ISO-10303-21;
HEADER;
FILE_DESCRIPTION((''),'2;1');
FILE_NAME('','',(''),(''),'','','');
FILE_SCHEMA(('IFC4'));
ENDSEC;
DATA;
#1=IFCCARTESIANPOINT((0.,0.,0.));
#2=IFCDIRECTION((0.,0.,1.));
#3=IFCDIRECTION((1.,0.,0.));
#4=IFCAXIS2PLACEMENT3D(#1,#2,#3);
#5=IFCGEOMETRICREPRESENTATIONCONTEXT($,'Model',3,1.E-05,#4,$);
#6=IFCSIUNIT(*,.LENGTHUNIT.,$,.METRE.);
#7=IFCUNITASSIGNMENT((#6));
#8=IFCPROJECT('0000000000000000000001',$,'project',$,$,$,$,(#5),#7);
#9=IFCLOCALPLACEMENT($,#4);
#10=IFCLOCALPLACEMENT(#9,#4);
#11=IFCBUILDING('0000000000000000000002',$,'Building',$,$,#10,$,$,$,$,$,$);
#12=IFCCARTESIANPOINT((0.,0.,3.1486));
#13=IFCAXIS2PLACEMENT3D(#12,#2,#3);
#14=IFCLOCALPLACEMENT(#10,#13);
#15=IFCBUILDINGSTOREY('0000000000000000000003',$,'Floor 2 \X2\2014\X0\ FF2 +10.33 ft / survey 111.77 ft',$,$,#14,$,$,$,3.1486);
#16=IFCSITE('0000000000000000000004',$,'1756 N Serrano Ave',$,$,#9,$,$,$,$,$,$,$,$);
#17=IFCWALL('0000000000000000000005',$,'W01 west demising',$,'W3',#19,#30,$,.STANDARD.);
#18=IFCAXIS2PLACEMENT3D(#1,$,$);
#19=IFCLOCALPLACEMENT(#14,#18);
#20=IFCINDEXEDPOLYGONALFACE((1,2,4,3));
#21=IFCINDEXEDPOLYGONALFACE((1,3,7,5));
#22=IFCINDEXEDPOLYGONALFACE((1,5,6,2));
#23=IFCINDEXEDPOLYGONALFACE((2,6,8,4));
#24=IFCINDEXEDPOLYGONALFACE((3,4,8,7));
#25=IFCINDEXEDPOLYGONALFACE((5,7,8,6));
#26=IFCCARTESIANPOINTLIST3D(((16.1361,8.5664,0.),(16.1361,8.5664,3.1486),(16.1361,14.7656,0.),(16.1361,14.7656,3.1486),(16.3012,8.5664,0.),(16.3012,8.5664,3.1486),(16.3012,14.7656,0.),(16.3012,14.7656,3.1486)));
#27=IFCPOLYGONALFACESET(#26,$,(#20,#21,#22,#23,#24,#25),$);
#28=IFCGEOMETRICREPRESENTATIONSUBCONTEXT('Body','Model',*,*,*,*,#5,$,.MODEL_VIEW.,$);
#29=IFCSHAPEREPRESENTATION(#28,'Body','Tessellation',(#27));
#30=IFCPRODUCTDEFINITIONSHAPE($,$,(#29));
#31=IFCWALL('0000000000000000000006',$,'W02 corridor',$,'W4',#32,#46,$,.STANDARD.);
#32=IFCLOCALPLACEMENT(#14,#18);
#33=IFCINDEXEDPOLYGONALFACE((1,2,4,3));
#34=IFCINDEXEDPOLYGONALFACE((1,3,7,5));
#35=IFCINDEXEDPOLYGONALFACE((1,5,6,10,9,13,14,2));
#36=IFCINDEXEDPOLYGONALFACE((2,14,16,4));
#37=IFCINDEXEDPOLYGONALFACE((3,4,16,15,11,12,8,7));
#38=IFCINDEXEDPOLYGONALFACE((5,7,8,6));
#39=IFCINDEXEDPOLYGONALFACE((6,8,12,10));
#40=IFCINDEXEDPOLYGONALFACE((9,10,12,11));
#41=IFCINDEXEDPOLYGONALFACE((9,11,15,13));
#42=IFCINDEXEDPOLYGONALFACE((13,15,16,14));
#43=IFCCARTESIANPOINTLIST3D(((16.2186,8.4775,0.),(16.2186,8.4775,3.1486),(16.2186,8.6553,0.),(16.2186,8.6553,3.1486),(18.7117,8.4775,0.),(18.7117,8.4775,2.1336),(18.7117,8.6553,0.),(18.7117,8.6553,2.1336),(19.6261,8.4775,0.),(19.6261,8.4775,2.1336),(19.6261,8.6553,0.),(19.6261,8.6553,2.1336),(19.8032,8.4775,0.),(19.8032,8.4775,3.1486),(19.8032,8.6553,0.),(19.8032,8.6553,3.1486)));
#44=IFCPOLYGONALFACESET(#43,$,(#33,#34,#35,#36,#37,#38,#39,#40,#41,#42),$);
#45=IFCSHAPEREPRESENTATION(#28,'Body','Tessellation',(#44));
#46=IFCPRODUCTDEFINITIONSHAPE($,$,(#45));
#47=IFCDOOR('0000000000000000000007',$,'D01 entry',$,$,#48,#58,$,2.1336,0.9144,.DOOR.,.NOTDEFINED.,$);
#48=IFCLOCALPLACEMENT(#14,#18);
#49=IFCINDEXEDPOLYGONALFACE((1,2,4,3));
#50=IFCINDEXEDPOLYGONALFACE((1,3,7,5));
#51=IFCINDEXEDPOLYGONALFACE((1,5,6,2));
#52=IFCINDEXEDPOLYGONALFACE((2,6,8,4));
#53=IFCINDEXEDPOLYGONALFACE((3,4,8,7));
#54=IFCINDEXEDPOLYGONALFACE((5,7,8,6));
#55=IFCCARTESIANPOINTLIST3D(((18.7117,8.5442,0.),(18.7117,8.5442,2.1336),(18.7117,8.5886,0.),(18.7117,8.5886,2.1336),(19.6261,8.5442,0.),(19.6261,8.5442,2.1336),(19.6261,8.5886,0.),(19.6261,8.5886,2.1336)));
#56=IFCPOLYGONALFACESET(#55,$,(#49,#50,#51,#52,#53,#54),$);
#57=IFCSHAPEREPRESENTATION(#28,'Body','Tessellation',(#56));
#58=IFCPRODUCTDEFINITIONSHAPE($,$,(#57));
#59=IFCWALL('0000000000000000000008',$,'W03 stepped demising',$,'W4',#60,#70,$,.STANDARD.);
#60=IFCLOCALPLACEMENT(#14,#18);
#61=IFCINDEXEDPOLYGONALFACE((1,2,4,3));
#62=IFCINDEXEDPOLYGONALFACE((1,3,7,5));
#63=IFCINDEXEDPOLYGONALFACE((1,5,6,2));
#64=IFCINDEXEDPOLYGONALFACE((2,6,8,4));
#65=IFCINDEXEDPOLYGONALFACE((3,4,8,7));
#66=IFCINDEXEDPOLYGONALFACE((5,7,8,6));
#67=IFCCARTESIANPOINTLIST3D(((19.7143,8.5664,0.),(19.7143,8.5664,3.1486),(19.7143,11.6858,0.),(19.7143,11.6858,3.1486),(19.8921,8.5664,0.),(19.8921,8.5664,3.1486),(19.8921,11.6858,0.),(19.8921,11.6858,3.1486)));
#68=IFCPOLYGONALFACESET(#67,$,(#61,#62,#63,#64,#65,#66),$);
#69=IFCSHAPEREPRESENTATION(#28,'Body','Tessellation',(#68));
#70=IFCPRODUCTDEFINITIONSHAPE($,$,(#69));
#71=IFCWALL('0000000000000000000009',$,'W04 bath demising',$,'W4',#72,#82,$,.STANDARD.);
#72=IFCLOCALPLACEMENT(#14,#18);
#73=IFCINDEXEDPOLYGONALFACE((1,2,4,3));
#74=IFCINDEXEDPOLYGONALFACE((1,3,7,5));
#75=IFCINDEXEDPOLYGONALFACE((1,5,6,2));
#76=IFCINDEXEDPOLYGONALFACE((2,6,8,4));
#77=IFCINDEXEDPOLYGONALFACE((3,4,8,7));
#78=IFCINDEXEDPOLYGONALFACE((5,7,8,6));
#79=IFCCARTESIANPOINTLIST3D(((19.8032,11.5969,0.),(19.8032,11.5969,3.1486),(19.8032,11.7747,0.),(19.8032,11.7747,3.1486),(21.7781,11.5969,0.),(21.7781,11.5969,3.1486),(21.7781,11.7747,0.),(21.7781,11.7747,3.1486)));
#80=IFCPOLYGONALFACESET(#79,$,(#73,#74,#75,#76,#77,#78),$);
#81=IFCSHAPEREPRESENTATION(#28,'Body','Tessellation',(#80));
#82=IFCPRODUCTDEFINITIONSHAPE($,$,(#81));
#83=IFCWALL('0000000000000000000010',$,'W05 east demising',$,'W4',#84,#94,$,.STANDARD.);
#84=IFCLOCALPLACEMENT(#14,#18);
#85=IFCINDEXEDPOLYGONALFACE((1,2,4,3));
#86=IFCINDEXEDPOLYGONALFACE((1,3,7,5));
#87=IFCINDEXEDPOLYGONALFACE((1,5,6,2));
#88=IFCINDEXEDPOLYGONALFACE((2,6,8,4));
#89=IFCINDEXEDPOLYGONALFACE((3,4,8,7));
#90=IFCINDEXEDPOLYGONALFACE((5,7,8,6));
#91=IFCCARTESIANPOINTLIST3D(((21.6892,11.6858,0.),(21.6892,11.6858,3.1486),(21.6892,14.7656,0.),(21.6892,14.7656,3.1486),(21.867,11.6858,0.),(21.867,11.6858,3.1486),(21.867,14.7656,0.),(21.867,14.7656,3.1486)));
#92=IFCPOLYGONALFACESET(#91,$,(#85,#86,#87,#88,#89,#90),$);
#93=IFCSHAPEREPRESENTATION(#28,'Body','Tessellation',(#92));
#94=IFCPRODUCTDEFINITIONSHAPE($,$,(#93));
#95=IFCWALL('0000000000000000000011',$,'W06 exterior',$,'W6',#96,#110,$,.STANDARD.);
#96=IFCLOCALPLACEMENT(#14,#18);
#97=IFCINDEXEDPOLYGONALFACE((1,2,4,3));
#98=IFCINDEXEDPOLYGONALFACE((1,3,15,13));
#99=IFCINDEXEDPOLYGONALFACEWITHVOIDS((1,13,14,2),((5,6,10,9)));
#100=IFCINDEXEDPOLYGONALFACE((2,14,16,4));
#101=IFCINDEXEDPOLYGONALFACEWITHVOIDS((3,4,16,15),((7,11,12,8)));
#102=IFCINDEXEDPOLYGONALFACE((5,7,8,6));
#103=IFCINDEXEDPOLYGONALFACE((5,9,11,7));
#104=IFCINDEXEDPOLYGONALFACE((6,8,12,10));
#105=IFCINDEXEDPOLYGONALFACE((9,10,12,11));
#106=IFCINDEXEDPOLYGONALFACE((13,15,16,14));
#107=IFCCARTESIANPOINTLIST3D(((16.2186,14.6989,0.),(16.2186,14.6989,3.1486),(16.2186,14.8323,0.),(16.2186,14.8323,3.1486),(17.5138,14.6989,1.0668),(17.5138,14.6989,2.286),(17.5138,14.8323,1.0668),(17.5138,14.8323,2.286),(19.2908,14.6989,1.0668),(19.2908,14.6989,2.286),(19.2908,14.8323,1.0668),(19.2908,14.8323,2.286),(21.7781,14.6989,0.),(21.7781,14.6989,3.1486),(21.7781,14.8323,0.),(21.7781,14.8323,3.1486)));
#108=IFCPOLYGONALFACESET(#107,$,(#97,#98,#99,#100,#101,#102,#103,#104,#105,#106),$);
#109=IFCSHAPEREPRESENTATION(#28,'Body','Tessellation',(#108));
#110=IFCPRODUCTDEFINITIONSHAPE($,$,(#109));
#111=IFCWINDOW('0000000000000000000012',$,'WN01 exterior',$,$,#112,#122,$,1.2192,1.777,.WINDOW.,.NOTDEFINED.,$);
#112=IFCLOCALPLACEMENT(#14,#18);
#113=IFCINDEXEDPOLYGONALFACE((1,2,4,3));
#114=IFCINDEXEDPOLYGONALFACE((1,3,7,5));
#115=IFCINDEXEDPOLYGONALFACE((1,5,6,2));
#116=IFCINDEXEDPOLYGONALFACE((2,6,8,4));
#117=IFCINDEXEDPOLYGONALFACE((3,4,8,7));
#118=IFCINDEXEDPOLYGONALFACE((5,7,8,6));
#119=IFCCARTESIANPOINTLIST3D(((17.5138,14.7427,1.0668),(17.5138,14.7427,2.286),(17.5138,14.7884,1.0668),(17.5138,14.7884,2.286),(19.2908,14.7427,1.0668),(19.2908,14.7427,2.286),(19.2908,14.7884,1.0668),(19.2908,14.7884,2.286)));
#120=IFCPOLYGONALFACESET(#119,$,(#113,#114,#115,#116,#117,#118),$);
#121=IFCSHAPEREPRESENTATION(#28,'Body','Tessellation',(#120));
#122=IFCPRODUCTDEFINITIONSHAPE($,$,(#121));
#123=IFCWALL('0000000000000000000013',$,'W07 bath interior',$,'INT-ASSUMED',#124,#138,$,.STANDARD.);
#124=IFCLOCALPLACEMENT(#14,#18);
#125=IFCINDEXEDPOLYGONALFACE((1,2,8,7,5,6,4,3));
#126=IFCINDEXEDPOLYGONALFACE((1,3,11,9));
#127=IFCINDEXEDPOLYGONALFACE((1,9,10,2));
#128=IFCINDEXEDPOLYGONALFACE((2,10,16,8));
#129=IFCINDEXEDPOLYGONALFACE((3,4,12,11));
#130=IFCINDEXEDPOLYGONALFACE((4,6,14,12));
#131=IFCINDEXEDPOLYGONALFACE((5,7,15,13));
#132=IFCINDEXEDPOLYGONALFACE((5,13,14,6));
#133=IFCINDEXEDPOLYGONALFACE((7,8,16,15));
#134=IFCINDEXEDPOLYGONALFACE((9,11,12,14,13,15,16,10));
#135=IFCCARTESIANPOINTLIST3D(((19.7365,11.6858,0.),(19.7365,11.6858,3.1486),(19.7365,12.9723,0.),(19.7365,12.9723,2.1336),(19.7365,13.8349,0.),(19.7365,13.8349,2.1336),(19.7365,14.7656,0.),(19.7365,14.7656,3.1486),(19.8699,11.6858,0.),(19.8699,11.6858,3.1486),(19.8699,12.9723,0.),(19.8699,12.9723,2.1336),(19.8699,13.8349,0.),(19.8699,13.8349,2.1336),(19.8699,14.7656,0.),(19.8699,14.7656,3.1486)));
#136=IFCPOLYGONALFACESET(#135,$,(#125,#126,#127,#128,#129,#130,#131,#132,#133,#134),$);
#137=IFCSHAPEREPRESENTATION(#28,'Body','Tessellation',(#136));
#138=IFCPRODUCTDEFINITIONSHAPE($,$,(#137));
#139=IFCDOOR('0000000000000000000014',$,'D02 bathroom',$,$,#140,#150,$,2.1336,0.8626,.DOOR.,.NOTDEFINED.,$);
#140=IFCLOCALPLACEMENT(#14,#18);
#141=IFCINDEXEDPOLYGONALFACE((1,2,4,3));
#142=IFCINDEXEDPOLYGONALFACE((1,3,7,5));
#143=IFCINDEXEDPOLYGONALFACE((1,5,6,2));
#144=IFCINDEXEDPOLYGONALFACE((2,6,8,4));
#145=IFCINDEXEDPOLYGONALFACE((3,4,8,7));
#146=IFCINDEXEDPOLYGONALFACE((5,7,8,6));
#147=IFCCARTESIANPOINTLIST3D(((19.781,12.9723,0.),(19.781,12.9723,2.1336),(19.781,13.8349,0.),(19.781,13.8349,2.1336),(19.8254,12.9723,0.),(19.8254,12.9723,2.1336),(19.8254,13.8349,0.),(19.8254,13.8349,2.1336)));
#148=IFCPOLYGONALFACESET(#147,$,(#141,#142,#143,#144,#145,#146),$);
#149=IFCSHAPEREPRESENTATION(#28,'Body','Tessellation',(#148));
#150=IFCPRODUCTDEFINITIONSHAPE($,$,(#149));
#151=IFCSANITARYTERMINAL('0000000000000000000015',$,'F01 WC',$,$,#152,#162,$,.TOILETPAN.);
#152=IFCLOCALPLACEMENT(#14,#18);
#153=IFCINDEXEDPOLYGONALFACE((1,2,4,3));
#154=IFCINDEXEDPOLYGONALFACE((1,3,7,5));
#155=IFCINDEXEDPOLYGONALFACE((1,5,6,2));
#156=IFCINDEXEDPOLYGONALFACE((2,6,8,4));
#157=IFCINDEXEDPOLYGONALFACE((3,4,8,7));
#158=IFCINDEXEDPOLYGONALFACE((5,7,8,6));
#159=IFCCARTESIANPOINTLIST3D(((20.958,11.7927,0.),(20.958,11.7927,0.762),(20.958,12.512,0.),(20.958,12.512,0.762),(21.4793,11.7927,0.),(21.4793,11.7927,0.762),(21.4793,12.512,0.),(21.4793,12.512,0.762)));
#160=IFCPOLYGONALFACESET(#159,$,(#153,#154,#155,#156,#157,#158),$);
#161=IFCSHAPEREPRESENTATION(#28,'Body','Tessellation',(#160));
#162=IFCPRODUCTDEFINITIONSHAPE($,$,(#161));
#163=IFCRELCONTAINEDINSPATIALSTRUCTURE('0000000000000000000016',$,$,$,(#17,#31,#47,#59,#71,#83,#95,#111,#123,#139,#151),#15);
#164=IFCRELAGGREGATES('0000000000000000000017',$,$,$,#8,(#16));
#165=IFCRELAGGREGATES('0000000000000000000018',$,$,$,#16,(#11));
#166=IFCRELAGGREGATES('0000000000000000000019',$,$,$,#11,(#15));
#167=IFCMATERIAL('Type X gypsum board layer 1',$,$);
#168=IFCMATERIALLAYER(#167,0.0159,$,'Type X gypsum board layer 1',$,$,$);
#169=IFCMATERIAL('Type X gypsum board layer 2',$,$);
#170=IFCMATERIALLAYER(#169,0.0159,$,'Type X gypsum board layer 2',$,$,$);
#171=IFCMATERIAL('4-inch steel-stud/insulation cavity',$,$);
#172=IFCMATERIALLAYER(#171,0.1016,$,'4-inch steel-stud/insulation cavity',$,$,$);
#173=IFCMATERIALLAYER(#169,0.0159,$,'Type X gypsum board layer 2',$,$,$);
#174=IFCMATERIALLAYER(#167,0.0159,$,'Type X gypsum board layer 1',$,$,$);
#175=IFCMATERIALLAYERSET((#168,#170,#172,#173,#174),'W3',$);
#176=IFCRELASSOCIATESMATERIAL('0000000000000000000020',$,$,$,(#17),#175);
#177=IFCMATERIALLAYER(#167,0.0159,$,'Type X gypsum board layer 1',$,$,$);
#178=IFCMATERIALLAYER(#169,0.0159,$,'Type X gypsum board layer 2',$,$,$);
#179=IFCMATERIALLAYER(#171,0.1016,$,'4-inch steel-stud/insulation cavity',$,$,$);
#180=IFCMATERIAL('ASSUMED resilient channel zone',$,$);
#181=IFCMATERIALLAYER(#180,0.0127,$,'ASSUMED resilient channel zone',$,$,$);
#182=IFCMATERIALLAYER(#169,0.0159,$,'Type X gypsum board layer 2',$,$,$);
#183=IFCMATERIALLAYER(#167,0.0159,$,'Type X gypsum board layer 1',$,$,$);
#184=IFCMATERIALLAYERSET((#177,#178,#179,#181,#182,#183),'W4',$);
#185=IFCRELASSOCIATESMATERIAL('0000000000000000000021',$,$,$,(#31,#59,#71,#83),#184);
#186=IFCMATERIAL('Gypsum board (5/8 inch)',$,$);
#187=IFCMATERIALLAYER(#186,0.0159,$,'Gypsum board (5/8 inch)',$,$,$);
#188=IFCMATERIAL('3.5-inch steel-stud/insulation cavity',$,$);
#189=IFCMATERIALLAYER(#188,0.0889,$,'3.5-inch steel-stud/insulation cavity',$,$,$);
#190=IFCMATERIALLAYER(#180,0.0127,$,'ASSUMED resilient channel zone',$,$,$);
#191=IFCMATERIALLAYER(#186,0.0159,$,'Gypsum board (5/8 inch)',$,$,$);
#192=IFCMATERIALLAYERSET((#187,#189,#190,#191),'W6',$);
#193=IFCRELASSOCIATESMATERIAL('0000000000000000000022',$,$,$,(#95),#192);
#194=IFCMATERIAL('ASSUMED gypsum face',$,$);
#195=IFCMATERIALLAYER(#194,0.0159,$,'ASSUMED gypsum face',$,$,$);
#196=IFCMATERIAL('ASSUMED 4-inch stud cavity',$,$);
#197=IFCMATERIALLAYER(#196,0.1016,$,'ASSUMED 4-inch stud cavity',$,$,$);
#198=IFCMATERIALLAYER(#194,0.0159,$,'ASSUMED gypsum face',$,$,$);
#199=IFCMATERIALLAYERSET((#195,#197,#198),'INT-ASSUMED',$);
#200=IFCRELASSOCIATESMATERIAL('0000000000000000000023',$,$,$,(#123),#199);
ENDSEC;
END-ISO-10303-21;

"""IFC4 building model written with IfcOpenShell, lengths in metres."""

from ifc_helpers import new_model, si_unit, frame, frame_2d, origin, origin_with_axes, place, context, subcontext, project, spatial, rectangle, extrude, material, layer, layer_set, layer_usage, element, fill, save


model = new_model("IFC4")

# Units and contexts
model_context = context("Model", 3, precision=1e-05, world=origin_with_axes())
body_context = subcontext(model_context, "Body", "Model", "MODEL_VIEW")
ifc_project = project(units=[si_unit("LENGTHUNIT", "METRE")], contexts=[model_context])

# Site, building, storey
site_placement = place(None, origin_with_axes())
site = spatial("IfcSite", under=ifc_project, at=site_placement, Name="1756 N Serrano Ave")
building_placement = place(site_placement, origin_with_axes())
building = spatial("IfcBuilding", under=site, at=building_placement, Name="Building")
storey_placement = place(building_placement, frame((0.0, 0.0, 3.1486), z_axis=(0.0, 0.0, 1.0), x_axis=(1.0, 0.0, 0.0)))
storey = spatial("IfcBuildingStorey", under=building, at=storey_placement, Name="Floor 2 — FF2 +10.33 ft / survey 111.77 ft", Elevation=3.1486)

# Wall
ifc_material_1 = material(Name="Type X gypsum board layer 1")
ifc_layer_1 = layer(ifc_material_1, 0.0159, Name="Type X gypsum board layer 1")
ifc_material_2 = material(Name="Type X gypsum board layer 2")
ifc_layer_2 = layer(ifc_material_2, 0.0159, Name="Type X gypsum board layer 2")
ifc_material_3 = material(Name="4-inch steel-stud/insulation cavity")
ifc_layer_3 = layer(ifc_material_3, 0.1016, Name="4-inch steel-stud/insulation cavity")
ifc_layer_4 = layer(ifc_material_2, 0.0159, Name="Type X gypsum board layer 2")
ifc_layer_5 = layer(ifc_material_1, 0.0159, Name="Type X gypsum board layer 1")
ifc_layer_set_1 = layer_set([ifc_layer_1, ifc_layer_2, ifc_layer_3, ifc_layer_4, ifc_layer_5], Name="W3")
ifc_layer_usage_1 = layer_usage(ifc_layer_set_1, "AXIS2", "POSITIVE", -0.0825)
wall_1_placement = place(storey_placement, frame((16.2186, 8.5664, 0.0), z_axis=(0.0, 0.0, 1.0), x_axis=(0.0, 1.0, 0.0)))
element("IfcWall", 1, at=wall_1_placement, inside=storey, material=ifc_layer_usage_1, Name="W01 west demising", ObjectType="W3", PredefinedType="STANDARD", context=body_context, shape_type="SweptSolid", body=[
    extrude(rectangle(XDim=6.1992, YDim=0.1651, at=frame_2d((3.0996, 0.0))), origin(), (0.0, 0.0, 1.0), 3.1486),
])

# Wall, opening, door
ifc_layer_6 = layer(ifc_material_1, 0.0159, Name="Type X gypsum board layer 1")
ifc_layer_7 = layer(ifc_material_2, 0.0159, Name="Type X gypsum board layer 2")
ifc_layer_8 = layer(ifc_material_3, 0.1016, Name="4-inch steel-stud/insulation cavity")
ifc_material_4 = material(Name="ASSUMED resilient channel zone")
ifc_layer_9 = layer(ifc_material_4, 0.0127, Name="ASSUMED resilient channel zone")
ifc_layer_10 = layer(ifc_material_2, 0.0159, Name="Type X gypsum board layer 2")
ifc_layer_11 = layer(ifc_material_1, 0.0159, Name="Type X gypsum board layer 1")
ifc_layer_set_2 = layer_set([ifc_layer_6, ifc_layer_7, ifc_layer_8, ifc_layer_9, ifc_layer_10, ifc_layer_11], Name="W4")
ifc_layer_usage_2 = layer_usage(ifc_layer_set_2, "AXIS2", "POSITIVE", -0.0889)
wall_2_placement = place(storey_placement, frame((16.2186, 8.5664, 0.0), z_axis=(0.0, 0.0, 1.0), x_axis=(1.0, 0.0, 0.0)))
wall_2 = element("IfcWall", 2, at=wall_2_placement, inside=storey, material=ifc_layer_usage_2, Name="W02 corridor", ObjectType="W4", PredefinedType="STANDARD", context=body_context, shape_type="SweptSolid", body=[
    extrude(rectangle(XDim=3.5846, YDim=0.1778, at=frame_2d((1.7923, 0.0))), origin(), (0.0, 0.0, 1.0), 3.1486),
])
opening_1_placement = place(None, frame((19.6261, 8.5664, 3.1486), z_axis=(0.0, 0.0, 1.0), x_axis=(-1.0, 0.0, 0.0)))
opening_1 = element("IfcOpeningElement", 3, at=opening_1_placement, cuts=wall_2, PredefinedType="OPENING", context=body_context, shape_type="SweptSolid", body=[
    extrude(rectangle(XDim=0.9144, YDim=0.2083, at=frame_2d((0.4572, 0.0))), origin(), (0.0, 0.0, 1.0), 2.1336),
])
door_1_placement = place(storey_placement, frame((19.6261, 8.5664, 0.0), z_axis=(0.0, 0.0, 1.0), x_axis=(-1.0, 0.0, 0.0)))
door_1 = element("IfcDoor", 4, at=door_1_placement, inside=storey, Name="D01 entry", OperationType="NOTDEFINED", OverallHeight=2.1336, OverallWidth=0.9144, PredefinedType="DOOR", context=body_context, shape_type="SweptSolid", body=[
    extrude(rectangle(XDim=0.9144, YDim=0.0445, at=frame_2d((0.4572, 0.0))), origin(), (0.0, 0.0, 1.0), 2.1336),
])
fill(opening_1, door_1)

# Walls
ifc_layer_usage_3 = layer_usage(ifc_layer_set_2, "AXIS2", "POSITIVE", -0.0889)
wall_3_placement = place(storey_placement, frame((19.8032, 8.5664, 0.0), z_axis=(0.0, 0.0, 1.0), x_axis=(0.0, 1.0, 0.0)))
element("IfcWall", 5, at=wall_3_placement, inside=storey, material=ifc_layer_usage_3, Name="W03 stepped demising", ObjectType="W4", PredefinedType="STANDARD", context=body_context, shape_type="SweptSolid", body=[
    extrude(rectangle(XDim=3.1194, YDim=0.1778, at=frame_2d((1.5597, 0.0))), origin(), (0.0, 0.0, 1.0), 3.1486),
])
ifc_layer_usage_4 = layer_usage(ifc_layer_set_2, "AXIS2", "POSITIVE", -0.0889)
wall_4_placement = place(storey_placement, frame((19.8032, 11.6858, 0.0), z_axis=(0.0, 0.0, 1.0), x_axis=(1.0, 0.0, 0.0)))
element("IfcWall", 6, at=wall_4_placement, inside=storey, material=ifc_layer_usage_4, Name="W04 bath demising", ObjectType="W4", PredefinedType="STANDARD", context=body_context, shape_type="SweptSolid", body=[
    extrude(rectangle(XDim=1.9748, YDim=0.1778, at=frame_2d((0.9874, 0.0))), origin(), (0.0, 0.0, 1.0), 3.1486),
])
ifc_layer_usage_5 = layer_usage(ifc_layer_set_2, "AXIS2", "POSITIVE", -0.0889)
wall_5_placement = place(storey_placement, frame((21.7781, 11.6858, 0.0), z_axis=(0.0, 0.0, 1.0), x_axis=(0.0, 1.0, 0.0)))
element("IfcWall", 7, at=wall_5_placement, inside=storey, material=ifc_layer_usage_5, Name="W05 east demising", ObjectType="W4", PredefinedType="STANDARD", context=body_context, shape_type="SweptSolid", body=[
    extrude(rectangle(XDim=3.0797, YDim=0.1778, at=frame_2d((1.5399, 0.0))), origin(), (0.0, 0.0, 1.0), 3.1486),
])

# Wall, opening, window
ifc_material_5 = material(Name="Gypsum board (5/8 inch)")
ifc_layer_12 = layer(ifc_material_5, 0.0159, Name="Gypsum board (5/8 inch)")
ifc_material_6 = material(Name="3.5-inch steel-stud/insulation cavity")
ifc_layer_13 = layer(ifc_material_6, 0.0889, Name="3.5-inch steel-stud/insulation cavity")
ifc_layer_14 = layer(ifc_material_4, 0.0127, Name="ASSUMED resilient channel zone")
ifc_layer_15 = layer(ifc_material_5, 0.0159, Name="Gypsum board (5/8 inch)")
ifc_layer_set_3 = layer_set([ifc_layer_12, ifc_layer_13, ifc_layer_14, ifc_layer_15], Name="W6")
ifc_layer_usage_6 = layer_usage(ifc_layer_set_3, "AXIS2", "POSITIVE", -0.0667)
wall_6_placement = place(storey_placement, frame((16.2186, 14.7656, 0.0), z_axis=(0.0, 0.0, 1.0), x_axis=(1.0, 0.0, 0.0)))
wall_6 = element("IfcWall", 8, at=wall_6_placement, inside=storey, material=ifc_layer_usage_6, Name="W06 exterior", ObjectType="W6", PredefinedType="STANDARD", context=body_context, shape_type="SweptSolid", body=[
    extrude(rectangle(XDim=5.5594, YDim=0.1333, at=frame_2d((2.7797, 0.0))), origin(), (0.0, 0.0, 1.0), 3.1486),
])
opening_2_placement = place(None, frame((17.5138, 14.7656, 4.2154), z_axis=(0.0, 0.0, 1.0), x_axis=(1.0, 0.0, 0.0)))
opening_2 = element("IfcOpeningElement", 9, at=opening_2_placement, cuts=wall_6, PredefinedType="OPENING", context=body_context, shape_type="SweptSolid", body=[
    extrude(rectangle(XDim=1.777, YDim=0.1638, at=frame_2d((0.8885, 0.0))), origin(), (0.0, 0.0, 1.0), 1.2192),
])
window_placement = place(storey_placement, frame((17.5138, 14.7656, 1.0668), z_axis=(0.0, 0.0, 1.0), x_axis=(1.0, 0.0, 0.0)))
window = element("IfcWindow", 10, at=window_placement, inside=storey, Name="WN01 exterior", OverallHeight=1.2192, OverallWidth=1.777, PartitioningType="NOTDEFINED", PredefinedType="WINDOW", context=body_context, shape_type="SweptSolid", body=[
    extrude(rectangle(XDim=1.777, YDim=0.0457, at=frame_2d((0.8885, 0.0))), origin(), (0.0, 0.0, 1.0), 1.2192),
])
fill(opening_2, window)

# Wall, opening, door
ifc_material_7 = material(Name="ASSUMED gypsum face")
ifc_layer_16 = layer(ifc_material_7, 0.0159, Name="ASSUMED gypsum face")
ifc_material_8 = material(Name="ASSUMED 4-inch stud cavity")
ifc_layer_17 = layer(ifc_material_8, 0.1016, Name="ASSUMED 4-inch stud cavity")
ifc_layer_18 = layer(ifc_material_7, 0.0159, Name="ASSUMED gypsum face")
ifc_layer_set_4 = layer_set([ifc_layer_16, ifc_layer_17, ifc_layer_18], Name="INT-ASSUMED")
ifc_layer_usage_7 = layer_usage(ifc_layer_set_4, "AXIS2", "POSITIVE", -0.0667)
wall_7_placement = place(storey_placement, frame((19.8032, 11.6858, 0.0), z_axis=(0.0, 0.0, 1.0), x_axis=(0.0, 1.0, 0.0)))
wall_7 = element("IfcWall", 11, at=wall_7_placement, inside=storey, material=ifc_layer_usage_7, Name="W07 bath interior", ObjectType="INT-ASSUMED", PredefinedType="STANDARD", context=body_context, shape_type="SweptSolid", body=[
    extrude(rectangle(XDim=3.0797, YDim=0.1333, at=frame_2d((1.5399, 0.0))), origin(), (0.0, 0.0, 1.0), 3.1486),
])
opening_3_placement = place(None, frame((19.8032, 13.8349, 3.1486), z_axis=(0.0, 0.0, 1.0), x_axis=(0.0, -1.0, 0.0)))
opening_3 = element("IfcOpeningElement", 12, at=opening_3_placement, cuts=wall_7, PredefinedType="OPENING", context=body_context, shape_type="SweptSolid", body=[
    extrude(rectangle(XDim=0.8626, YDim=0.1638, at=frame_2d((0.4313, 0.0))), origin(), (0.0, 0.0, 1.0), 2.1336),
])
door_2_placement = place(storey_placement, frame((19.8032, 13.8349, 0.0), z_axis=(0.0, 0.0, 1.0), x_axis=(0.0, -1.0, 0.0)))
door_2 = element("IfcDoor", 13, at=door_2_placement, inside=storey, Name="D02 bathroom", OperationType="NOTDEFINED", OverallHeight=2.1336, OverallWidth=0.8626, PredefinedType="DOOR", context=body_context, shape_type="SweptSolid", body=[
    extrude(rectangle(XDim=0.8626, YDim=0.0445, at=frame_2d((0.4313, 0.0))), origin(), (0.0, 0.0, 1.0), 2.1336),
])
fill(opening_3, door_2)

# Sanitary terminal
sanitary_terminal_1_placement = place(storey_placement, frame((20.958, 12.1524, 0.0), z_axis=(0.0, 0.0, 1.0), x_axis=(1.0, 0.0, 0.0)))
element("IfcSanitaryTerminal", 14, at=sanitary_terminal_1_placement, inside=storey, Name="F01 WC", PredefinedType="TOILETPAN", context=body_context, shape_type="SweptSolid", body=[
    extrude(rectangle(XDim=0.5212, YDim=0.7193, at=frame_2d((0.2606, 0.0))), origin(), (0.0, 0.0, 1.0), 0.762),
])

save(model, "model.ifc")
